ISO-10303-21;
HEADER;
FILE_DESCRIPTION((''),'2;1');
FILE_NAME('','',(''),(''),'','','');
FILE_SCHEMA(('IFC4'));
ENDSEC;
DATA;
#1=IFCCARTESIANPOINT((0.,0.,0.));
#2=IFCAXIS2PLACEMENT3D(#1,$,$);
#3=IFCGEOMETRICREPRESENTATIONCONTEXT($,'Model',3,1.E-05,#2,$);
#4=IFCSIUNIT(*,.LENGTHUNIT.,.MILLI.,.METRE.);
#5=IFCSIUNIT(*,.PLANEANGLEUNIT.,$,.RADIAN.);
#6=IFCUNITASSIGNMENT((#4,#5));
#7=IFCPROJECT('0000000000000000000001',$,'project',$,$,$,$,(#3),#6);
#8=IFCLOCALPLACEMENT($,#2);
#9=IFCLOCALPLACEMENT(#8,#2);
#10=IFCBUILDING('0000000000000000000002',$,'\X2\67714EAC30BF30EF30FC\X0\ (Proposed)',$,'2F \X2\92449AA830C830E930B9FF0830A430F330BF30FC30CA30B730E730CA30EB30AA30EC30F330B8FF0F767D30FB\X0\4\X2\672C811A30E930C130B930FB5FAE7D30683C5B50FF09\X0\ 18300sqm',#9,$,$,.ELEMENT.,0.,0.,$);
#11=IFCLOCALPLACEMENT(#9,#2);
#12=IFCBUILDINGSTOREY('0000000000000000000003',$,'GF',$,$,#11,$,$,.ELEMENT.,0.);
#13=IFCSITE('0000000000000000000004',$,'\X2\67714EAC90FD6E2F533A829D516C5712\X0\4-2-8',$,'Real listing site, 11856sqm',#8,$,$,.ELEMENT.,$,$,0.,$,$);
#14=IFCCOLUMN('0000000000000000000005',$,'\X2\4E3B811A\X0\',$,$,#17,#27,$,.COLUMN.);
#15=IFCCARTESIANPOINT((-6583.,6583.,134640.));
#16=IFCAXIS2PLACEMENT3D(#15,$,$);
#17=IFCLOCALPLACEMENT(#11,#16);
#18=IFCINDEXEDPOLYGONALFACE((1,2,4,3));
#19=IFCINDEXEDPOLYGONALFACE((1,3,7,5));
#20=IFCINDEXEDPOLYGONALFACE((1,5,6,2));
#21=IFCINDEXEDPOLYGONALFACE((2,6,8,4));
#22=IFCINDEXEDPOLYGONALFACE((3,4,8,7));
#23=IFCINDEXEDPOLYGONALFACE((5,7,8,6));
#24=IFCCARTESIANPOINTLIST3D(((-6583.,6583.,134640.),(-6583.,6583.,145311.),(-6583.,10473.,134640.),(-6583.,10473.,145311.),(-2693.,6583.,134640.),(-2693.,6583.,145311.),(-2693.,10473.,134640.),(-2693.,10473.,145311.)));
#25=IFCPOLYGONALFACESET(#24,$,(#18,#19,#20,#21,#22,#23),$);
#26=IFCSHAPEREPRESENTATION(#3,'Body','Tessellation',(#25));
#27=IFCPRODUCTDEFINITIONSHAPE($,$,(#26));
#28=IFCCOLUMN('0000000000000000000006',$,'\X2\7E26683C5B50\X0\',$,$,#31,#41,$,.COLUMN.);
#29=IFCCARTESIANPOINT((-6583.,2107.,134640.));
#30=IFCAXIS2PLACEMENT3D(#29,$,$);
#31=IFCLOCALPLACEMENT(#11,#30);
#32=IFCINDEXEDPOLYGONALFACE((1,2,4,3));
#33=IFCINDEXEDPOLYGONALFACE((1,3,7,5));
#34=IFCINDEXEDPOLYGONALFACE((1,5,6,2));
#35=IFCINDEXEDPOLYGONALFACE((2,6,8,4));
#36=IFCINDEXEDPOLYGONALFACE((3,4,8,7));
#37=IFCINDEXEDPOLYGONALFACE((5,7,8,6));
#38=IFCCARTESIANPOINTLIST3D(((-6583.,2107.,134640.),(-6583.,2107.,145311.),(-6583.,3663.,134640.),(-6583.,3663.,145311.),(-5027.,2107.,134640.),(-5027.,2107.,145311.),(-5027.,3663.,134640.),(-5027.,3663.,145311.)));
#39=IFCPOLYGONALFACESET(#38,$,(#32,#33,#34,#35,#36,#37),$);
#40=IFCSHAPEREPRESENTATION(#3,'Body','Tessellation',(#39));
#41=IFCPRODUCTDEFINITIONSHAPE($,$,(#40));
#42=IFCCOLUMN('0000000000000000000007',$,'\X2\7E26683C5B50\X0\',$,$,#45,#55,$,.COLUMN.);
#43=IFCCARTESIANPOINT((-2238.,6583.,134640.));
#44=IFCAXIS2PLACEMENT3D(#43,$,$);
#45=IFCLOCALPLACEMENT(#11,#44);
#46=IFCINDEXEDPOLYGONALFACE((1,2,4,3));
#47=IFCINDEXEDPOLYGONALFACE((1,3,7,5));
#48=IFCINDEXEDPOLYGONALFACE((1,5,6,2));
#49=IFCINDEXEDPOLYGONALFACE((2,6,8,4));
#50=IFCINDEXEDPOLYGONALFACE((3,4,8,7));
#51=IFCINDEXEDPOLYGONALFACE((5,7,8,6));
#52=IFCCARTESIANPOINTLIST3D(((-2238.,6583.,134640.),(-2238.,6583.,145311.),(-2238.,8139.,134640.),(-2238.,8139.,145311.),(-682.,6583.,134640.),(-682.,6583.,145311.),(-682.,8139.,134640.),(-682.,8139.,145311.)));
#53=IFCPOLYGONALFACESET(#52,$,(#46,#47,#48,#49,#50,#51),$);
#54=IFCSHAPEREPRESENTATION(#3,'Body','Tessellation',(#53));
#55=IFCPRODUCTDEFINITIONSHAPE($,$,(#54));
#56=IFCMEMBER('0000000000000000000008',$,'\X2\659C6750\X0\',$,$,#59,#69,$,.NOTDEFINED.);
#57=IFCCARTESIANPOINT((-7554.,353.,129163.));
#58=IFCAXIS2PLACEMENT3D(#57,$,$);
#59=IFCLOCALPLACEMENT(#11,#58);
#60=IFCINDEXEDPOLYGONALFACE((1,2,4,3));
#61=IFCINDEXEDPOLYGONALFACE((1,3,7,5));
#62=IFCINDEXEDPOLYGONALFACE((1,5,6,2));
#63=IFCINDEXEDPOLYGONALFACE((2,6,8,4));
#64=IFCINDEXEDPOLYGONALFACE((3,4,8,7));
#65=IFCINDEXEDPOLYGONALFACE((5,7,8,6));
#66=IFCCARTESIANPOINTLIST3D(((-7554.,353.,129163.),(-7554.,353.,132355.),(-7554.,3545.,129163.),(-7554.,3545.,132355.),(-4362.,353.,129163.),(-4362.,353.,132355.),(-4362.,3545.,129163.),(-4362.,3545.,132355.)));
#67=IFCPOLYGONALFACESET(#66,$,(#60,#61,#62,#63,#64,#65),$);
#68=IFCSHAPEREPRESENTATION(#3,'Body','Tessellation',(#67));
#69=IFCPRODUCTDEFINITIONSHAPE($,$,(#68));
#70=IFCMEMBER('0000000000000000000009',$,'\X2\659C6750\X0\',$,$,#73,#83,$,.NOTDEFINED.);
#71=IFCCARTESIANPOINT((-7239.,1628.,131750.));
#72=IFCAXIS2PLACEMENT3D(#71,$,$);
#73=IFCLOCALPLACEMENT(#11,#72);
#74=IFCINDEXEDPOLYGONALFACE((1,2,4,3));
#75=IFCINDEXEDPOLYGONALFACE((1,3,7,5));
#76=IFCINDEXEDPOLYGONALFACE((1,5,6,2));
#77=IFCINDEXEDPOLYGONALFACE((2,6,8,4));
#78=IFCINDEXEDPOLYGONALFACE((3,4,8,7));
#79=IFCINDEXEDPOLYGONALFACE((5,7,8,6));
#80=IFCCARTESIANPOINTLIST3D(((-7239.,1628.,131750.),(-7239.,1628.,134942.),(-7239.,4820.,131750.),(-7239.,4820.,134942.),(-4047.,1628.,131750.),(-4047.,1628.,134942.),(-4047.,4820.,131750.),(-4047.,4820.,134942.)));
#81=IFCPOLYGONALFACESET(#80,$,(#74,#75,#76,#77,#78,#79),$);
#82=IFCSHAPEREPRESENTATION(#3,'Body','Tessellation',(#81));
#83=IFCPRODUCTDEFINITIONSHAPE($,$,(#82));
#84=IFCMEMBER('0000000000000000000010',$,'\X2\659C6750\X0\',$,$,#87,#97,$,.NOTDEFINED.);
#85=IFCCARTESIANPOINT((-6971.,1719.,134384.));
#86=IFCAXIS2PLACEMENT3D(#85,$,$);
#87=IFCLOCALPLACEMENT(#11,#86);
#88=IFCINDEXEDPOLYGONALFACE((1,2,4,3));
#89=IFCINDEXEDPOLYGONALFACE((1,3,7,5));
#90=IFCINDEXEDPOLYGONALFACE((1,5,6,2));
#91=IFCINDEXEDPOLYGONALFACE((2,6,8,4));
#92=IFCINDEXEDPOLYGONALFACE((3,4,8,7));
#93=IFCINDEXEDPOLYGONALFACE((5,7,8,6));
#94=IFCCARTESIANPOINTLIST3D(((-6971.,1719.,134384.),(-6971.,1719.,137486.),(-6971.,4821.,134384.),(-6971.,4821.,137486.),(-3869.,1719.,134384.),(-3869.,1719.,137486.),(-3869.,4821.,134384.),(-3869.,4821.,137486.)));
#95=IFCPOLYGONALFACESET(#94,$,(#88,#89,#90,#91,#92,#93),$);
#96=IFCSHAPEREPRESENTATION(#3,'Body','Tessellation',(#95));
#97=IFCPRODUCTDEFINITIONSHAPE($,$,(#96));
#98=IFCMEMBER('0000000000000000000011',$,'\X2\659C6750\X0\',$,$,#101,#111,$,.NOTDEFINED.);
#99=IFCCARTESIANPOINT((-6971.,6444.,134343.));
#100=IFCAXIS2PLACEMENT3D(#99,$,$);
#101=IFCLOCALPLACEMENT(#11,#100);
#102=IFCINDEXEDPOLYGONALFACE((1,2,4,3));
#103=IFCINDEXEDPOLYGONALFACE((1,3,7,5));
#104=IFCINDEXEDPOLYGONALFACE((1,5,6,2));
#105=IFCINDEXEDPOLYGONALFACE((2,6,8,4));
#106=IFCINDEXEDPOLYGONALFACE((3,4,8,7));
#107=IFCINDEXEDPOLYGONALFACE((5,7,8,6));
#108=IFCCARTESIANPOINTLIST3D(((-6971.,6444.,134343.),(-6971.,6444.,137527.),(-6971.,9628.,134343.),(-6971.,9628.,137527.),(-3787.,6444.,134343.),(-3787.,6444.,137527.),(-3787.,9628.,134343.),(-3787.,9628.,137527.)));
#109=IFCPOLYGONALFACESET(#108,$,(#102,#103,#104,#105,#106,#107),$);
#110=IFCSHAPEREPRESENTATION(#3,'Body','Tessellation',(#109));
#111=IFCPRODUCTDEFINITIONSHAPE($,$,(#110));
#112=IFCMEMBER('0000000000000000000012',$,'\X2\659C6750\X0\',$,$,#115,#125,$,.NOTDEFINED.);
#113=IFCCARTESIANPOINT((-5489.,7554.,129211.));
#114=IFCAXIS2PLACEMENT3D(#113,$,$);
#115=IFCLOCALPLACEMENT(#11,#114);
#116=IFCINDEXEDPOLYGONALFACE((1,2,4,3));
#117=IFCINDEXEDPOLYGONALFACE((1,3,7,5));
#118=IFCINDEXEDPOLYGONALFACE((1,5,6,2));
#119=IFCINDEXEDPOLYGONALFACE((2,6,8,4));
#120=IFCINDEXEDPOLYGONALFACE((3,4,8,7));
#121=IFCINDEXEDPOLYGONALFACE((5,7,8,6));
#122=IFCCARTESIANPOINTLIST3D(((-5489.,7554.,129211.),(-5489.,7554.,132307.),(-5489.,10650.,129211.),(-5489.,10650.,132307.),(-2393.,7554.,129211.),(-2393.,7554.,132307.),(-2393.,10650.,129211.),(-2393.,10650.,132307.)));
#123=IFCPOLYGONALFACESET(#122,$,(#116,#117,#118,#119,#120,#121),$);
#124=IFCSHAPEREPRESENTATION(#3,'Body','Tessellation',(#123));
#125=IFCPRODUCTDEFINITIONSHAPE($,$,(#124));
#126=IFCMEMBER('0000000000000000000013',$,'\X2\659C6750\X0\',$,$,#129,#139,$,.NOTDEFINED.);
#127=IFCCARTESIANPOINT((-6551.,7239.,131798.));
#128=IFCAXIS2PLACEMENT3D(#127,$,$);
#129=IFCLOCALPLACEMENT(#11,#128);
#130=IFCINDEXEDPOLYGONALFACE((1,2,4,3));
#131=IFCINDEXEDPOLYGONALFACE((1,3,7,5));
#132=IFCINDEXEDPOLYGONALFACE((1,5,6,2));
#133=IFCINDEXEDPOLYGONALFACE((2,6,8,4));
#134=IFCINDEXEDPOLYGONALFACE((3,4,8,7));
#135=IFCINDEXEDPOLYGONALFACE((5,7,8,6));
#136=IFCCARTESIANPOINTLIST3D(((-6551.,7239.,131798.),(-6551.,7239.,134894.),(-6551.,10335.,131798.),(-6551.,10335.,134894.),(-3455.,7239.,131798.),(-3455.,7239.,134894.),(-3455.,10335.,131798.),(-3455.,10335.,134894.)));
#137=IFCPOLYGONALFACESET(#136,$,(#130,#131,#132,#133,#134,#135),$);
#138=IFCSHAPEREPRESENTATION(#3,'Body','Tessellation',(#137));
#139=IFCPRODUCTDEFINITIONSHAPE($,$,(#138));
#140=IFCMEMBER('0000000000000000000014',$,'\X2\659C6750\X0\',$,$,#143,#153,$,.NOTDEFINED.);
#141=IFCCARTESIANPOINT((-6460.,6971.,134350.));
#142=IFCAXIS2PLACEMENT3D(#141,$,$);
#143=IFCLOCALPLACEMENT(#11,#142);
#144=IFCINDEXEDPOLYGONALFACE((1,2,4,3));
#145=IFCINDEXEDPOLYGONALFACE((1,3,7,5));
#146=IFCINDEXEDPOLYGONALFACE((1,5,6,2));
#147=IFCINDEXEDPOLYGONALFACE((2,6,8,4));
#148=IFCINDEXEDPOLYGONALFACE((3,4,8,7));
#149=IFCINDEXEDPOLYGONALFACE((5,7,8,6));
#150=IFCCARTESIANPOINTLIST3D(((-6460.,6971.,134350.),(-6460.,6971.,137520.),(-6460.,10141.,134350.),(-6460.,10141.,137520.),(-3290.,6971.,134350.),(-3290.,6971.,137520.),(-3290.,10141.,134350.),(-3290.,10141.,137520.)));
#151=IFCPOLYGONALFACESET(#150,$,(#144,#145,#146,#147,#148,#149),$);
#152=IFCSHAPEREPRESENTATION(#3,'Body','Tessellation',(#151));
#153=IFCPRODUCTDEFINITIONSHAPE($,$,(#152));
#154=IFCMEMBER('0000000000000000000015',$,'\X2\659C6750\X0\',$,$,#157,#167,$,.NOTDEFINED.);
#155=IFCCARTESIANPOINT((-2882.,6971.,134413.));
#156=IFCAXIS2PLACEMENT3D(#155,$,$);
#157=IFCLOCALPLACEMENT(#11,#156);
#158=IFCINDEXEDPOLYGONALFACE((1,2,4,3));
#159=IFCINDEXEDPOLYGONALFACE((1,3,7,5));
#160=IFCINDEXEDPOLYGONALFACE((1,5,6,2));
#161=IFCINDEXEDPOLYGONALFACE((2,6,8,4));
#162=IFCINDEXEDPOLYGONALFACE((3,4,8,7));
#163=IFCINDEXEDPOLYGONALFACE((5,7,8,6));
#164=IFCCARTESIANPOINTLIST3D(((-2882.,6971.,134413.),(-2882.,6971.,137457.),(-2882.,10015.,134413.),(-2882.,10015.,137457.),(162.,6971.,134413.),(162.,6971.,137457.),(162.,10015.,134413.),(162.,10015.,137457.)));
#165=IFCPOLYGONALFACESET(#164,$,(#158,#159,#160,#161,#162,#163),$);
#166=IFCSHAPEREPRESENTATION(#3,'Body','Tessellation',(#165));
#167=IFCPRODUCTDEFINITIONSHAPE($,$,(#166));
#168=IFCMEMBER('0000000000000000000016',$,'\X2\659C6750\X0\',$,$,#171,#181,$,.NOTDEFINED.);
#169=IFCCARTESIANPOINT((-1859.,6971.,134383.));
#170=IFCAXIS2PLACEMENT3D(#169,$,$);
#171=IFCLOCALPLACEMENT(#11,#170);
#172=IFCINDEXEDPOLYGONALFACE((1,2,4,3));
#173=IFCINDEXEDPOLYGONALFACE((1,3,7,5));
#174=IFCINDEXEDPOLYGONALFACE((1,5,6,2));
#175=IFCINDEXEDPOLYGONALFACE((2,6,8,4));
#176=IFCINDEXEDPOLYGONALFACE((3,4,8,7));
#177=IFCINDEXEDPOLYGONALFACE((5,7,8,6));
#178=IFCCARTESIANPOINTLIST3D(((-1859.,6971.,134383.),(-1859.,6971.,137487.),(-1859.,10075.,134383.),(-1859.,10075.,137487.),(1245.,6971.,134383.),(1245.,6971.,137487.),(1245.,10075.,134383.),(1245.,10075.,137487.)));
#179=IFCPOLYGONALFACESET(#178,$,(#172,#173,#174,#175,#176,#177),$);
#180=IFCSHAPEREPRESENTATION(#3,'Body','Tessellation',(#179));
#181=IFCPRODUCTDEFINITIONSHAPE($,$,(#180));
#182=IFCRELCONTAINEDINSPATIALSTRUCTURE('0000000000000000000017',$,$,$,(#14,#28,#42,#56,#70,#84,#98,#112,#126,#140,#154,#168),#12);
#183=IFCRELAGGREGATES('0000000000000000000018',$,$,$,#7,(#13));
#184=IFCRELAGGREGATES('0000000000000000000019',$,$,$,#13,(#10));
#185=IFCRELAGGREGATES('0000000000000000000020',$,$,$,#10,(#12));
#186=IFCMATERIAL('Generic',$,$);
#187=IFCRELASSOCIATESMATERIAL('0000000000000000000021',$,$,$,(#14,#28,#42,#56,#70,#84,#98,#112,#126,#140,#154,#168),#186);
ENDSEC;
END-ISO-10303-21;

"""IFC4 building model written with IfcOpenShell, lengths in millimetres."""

from ifc_helpers import new_model, si_unit, frame, frame_2d, origin, place, context, project, spatial, rectangle, extrude, material, element, save


model = new_model("IFC4")

# Units and contexts
model_context = context("Model", 3, precision=1e-05, world=origin())
ifc_project = project(units=[si_unit("LENGTHUNIT", "METRE", prefix="MILLI"), si_unit("PLANEANGLEUNIT", "RADIAN")], contexts=[model_context])

# Site, building, storey
site_placement = place(None, origin())
site = spatial("IfcSite", under=ifc_project, at=site_placement, Name="東京都港区芝公園4-2-8", ObjectType="Real listing site, 11856sqm", CompositionType="ELEMENT", RefElevation=0.0)
building_placement = place(site_placement, origin())
building = spatial("IfcBuilding", under=site, at=building_placement, Name="東京タワー (Proposed)", ObjectType="2F 鉄骨トラス（インターナショナルオレンジ／白・4本脚ラチス・微細格子） 18300sqm", CompositionType="ELEMENT", ElevationOfRefHeight=0.0, ElevationOfTerrain=0.0)
storey_placement = place(building_placement, origin())
storey = spatial("IfcBuildingStorey", under=building, at=storey_placement, Name="GF", CompositionType="ELEMENT", Elevation=0.0)

# Columns
ifc_material = material(Name="Generic")
column_1_placement = place(storey_placement, frame((-6583.0, 6583.0, 134640.0)))
element("IfcColumn", 1, at=column_1_placement, inside=storey, material=ifc_material, Name="主脚", PredefinedType="COLUMN", context=model_context, shape_type="SweptSolid", body=[
    extrude(rectangle(XDim=3890.0, YDim=3890.0, at=frame_2d((1945.0, 1945.0))), frame((-6583.0, 6583.0, 134640.0)), (0.0, 0.0, 1.0), 10671.0),
])
column_2_placement = place(storey_placement, frame((-6583.0, 2107.0, 134640.0)))
element("IfcColumn", 2, at=column_2_placement, inside=storey, material=ifc_material, Name="縦格子", PredefinedType="COLUMN", context=model_context, shape_type="SweptSolid", body=[
    extrude(rectangle(XDim=1556.0, YDim=1556.0, at=frame_2d((778.0, 778.0))), frame((-6583.0, 2107.0, 134640.0)), (0.0, 0.0, 1.0), 10671.0),
])
column_3_placement = place(storey_placement, frame((-2238.0, 6583.0, 134640.0)))
element("IfcColumn", 3, at=column_3_placement, inside=storey, material=ifc_material, Name="縦格子", PredefinedType="COLUMN", context=model_context, shape_type="SweptSolid", body=[
    extrude(rectangle(XDim=1556.0, YDim=1556.0, at=frame_2d((778.0, 778.0))), frame((-2238.0, 6583.0, 134640.0)), (0.0, 0.0, 1.0), 10671.0),
])

# Members
member_1_placement = place(storey_placement, frame((-7554.0, 353.0, 129163.0)))
element("IfcMember", 4, at=member_1_placement, inside=storey, material=ifc_material, Name="斜材", PredefinedType="NOTDEFINED", context=model_context, shape_type="SweptSolid", body=[
    extrude(rectangle(XDim=3192.0, YDim=3192.0, at=frame_2d((1596.0, 1596.0))), frame((-7554.0, 353.0, 129163.0)), (0.0, 0.0, 1.0), 3192.0),
])
member_2_placement = place(storey_placement, frame((-7239.0, 1628.0, 131750.0)))
element("IfcMember", 5, at=member_2_placement, inside=storey, material=ifc_material, Name="斜材", PredefinedType="NOTDEFINED", context=model_context, shape_type="SweptSolid", body=[
    extrude(rectangle(XDim=3192.0, YDim=3192.0, at=frame_2d((1596.0, 1596.0))), frame((-7239.0, 1628.0, 131750.0)), (0.0, 0.0, 1.0), 3192.0),
])
member_3_placement = place(storey_placement, frame((-6971.0, 1719.0, 134384.0)))
element("IfcMember", 6, at=member_3_placement, inside=storey, material=ifc_material, Name="斜材", PredefinedType="NOTDEFINED", context=model_context, shape_type="SweptSolid", body=[
    extrude(rectangle(XDim=3102.0, YDim=3102.0, at=frame_2d((1551.0, 1551.0))), frame((-6971.0, 1719.0, 134384.0)), (0.0, 0.0, 1.0), 3102.0),
])
member_4_placement = place(storey_placement, frame((-6971.0, 6444.0, 134343.0)))
element("IfcMember", 7, at=member_4_placement, inside=storey, material=ifc_material, Name="斜材", PredefinedType="NOTDEFINED", context=model_context, shape_type="SweptSolid", body=[
    extrude(rectangle(XDim=3184.0, YDim=3184.0, at=frame_2d((1592.0, 1592.0))), frame((-6971.0, 6444.0, 134343.0)), (0.0, 0.0, 1.0), 3184.0),
])
member_5_placement = place(storey_placement, frame((-5489.0, 7554.0, 129211.0)))
element("IfcMember", 8, at=member_5_placement, inside=storey, material=ifc_material, Name="斜材", PredefinedType="NOTDEFINED", context=model_context, shape_type="SweptSolid", body=[
    extrude(rectangle(XDim=3096.0, YDim=3096.0, at=frame_2d((1548.0, 1548.0))), frame((-5489.0, 7554.0, 129211.0)), (0.0, 0.0, 1.0), 3096.0),
])
member_6_placement = place(storey_placement, frame((-6551.0, 7239.0, 131798.0)))
element("IfcMember", 9, at=member_6_placement, inside=storey, material=ifc_material, Name="斜材", PredefinedType="NOTDEFINED", context=model_context, shape_type="SweptSolid", body=[
    extrude(rectangle(XDim=3096.0, YDim=3096.0, at=frame_2d((1548.0, 1548.0))), frame((-6551.0, 7239.0, 131798.0)), (0.0, 0.0, 1.0), 3096.0),
])
member_7_placement = place(storey_placement, frame((-6460.0, 6971.0, 134350.0)))
element("IfcMember", 10, at=member_7_placement, inside=storey, material=ifc_material, Name="斜材", PredefinedType="NOTDEFINED", context=model_context, shape_type="SweptSolid", body=[
    extrude(rectangle(XDim=3170.0, YDim=3170.0, at=frame_2d((1585.0, 1585.0))), frame((-6460.0, 6971.0, 134350.0)), (0.0, 0.0, 1.0), 3170.0),
])
member_8_placement = place(storey_placement, frame((-2882.0, 6971.0, 134413.0)))
element("IfcMember", 11, at=member_8_placement, inside=storey, material=ifc_material, Name="斜材", PredefinedType="NOTDEFINED", context=model_context, shape_type="SweptSolid", body=[
    extrude(rectangle(XDim=3044.0, YDim=3044.0, at=frame_2d((1522.0, 1522.0))), frame((-2882.0, 6971.0, 134413.0)), (0.0, 0.0, 1.0), 3044.0),
])
member_9_placement = place(storey_placement, frame((-1859.0, 6971.0, 134383.0)))
element("IfcMember", 12, at=member_9_placement, inside=storey, material=ifc_material, Name="斜材", PredefinedType="NOTDEFINED", context=model_context, shape_type="SweptSolid", body=[
    extrude(rectangle(XDim=3104.0, YDim=3104.0, at=frame_2d((1552.0, 1552.0))), frame((-1859.0, 6971.0, 134383.0)), (0.0, 0.0, 1.0), 3104.0),
])

save(model, "model.ifc")
